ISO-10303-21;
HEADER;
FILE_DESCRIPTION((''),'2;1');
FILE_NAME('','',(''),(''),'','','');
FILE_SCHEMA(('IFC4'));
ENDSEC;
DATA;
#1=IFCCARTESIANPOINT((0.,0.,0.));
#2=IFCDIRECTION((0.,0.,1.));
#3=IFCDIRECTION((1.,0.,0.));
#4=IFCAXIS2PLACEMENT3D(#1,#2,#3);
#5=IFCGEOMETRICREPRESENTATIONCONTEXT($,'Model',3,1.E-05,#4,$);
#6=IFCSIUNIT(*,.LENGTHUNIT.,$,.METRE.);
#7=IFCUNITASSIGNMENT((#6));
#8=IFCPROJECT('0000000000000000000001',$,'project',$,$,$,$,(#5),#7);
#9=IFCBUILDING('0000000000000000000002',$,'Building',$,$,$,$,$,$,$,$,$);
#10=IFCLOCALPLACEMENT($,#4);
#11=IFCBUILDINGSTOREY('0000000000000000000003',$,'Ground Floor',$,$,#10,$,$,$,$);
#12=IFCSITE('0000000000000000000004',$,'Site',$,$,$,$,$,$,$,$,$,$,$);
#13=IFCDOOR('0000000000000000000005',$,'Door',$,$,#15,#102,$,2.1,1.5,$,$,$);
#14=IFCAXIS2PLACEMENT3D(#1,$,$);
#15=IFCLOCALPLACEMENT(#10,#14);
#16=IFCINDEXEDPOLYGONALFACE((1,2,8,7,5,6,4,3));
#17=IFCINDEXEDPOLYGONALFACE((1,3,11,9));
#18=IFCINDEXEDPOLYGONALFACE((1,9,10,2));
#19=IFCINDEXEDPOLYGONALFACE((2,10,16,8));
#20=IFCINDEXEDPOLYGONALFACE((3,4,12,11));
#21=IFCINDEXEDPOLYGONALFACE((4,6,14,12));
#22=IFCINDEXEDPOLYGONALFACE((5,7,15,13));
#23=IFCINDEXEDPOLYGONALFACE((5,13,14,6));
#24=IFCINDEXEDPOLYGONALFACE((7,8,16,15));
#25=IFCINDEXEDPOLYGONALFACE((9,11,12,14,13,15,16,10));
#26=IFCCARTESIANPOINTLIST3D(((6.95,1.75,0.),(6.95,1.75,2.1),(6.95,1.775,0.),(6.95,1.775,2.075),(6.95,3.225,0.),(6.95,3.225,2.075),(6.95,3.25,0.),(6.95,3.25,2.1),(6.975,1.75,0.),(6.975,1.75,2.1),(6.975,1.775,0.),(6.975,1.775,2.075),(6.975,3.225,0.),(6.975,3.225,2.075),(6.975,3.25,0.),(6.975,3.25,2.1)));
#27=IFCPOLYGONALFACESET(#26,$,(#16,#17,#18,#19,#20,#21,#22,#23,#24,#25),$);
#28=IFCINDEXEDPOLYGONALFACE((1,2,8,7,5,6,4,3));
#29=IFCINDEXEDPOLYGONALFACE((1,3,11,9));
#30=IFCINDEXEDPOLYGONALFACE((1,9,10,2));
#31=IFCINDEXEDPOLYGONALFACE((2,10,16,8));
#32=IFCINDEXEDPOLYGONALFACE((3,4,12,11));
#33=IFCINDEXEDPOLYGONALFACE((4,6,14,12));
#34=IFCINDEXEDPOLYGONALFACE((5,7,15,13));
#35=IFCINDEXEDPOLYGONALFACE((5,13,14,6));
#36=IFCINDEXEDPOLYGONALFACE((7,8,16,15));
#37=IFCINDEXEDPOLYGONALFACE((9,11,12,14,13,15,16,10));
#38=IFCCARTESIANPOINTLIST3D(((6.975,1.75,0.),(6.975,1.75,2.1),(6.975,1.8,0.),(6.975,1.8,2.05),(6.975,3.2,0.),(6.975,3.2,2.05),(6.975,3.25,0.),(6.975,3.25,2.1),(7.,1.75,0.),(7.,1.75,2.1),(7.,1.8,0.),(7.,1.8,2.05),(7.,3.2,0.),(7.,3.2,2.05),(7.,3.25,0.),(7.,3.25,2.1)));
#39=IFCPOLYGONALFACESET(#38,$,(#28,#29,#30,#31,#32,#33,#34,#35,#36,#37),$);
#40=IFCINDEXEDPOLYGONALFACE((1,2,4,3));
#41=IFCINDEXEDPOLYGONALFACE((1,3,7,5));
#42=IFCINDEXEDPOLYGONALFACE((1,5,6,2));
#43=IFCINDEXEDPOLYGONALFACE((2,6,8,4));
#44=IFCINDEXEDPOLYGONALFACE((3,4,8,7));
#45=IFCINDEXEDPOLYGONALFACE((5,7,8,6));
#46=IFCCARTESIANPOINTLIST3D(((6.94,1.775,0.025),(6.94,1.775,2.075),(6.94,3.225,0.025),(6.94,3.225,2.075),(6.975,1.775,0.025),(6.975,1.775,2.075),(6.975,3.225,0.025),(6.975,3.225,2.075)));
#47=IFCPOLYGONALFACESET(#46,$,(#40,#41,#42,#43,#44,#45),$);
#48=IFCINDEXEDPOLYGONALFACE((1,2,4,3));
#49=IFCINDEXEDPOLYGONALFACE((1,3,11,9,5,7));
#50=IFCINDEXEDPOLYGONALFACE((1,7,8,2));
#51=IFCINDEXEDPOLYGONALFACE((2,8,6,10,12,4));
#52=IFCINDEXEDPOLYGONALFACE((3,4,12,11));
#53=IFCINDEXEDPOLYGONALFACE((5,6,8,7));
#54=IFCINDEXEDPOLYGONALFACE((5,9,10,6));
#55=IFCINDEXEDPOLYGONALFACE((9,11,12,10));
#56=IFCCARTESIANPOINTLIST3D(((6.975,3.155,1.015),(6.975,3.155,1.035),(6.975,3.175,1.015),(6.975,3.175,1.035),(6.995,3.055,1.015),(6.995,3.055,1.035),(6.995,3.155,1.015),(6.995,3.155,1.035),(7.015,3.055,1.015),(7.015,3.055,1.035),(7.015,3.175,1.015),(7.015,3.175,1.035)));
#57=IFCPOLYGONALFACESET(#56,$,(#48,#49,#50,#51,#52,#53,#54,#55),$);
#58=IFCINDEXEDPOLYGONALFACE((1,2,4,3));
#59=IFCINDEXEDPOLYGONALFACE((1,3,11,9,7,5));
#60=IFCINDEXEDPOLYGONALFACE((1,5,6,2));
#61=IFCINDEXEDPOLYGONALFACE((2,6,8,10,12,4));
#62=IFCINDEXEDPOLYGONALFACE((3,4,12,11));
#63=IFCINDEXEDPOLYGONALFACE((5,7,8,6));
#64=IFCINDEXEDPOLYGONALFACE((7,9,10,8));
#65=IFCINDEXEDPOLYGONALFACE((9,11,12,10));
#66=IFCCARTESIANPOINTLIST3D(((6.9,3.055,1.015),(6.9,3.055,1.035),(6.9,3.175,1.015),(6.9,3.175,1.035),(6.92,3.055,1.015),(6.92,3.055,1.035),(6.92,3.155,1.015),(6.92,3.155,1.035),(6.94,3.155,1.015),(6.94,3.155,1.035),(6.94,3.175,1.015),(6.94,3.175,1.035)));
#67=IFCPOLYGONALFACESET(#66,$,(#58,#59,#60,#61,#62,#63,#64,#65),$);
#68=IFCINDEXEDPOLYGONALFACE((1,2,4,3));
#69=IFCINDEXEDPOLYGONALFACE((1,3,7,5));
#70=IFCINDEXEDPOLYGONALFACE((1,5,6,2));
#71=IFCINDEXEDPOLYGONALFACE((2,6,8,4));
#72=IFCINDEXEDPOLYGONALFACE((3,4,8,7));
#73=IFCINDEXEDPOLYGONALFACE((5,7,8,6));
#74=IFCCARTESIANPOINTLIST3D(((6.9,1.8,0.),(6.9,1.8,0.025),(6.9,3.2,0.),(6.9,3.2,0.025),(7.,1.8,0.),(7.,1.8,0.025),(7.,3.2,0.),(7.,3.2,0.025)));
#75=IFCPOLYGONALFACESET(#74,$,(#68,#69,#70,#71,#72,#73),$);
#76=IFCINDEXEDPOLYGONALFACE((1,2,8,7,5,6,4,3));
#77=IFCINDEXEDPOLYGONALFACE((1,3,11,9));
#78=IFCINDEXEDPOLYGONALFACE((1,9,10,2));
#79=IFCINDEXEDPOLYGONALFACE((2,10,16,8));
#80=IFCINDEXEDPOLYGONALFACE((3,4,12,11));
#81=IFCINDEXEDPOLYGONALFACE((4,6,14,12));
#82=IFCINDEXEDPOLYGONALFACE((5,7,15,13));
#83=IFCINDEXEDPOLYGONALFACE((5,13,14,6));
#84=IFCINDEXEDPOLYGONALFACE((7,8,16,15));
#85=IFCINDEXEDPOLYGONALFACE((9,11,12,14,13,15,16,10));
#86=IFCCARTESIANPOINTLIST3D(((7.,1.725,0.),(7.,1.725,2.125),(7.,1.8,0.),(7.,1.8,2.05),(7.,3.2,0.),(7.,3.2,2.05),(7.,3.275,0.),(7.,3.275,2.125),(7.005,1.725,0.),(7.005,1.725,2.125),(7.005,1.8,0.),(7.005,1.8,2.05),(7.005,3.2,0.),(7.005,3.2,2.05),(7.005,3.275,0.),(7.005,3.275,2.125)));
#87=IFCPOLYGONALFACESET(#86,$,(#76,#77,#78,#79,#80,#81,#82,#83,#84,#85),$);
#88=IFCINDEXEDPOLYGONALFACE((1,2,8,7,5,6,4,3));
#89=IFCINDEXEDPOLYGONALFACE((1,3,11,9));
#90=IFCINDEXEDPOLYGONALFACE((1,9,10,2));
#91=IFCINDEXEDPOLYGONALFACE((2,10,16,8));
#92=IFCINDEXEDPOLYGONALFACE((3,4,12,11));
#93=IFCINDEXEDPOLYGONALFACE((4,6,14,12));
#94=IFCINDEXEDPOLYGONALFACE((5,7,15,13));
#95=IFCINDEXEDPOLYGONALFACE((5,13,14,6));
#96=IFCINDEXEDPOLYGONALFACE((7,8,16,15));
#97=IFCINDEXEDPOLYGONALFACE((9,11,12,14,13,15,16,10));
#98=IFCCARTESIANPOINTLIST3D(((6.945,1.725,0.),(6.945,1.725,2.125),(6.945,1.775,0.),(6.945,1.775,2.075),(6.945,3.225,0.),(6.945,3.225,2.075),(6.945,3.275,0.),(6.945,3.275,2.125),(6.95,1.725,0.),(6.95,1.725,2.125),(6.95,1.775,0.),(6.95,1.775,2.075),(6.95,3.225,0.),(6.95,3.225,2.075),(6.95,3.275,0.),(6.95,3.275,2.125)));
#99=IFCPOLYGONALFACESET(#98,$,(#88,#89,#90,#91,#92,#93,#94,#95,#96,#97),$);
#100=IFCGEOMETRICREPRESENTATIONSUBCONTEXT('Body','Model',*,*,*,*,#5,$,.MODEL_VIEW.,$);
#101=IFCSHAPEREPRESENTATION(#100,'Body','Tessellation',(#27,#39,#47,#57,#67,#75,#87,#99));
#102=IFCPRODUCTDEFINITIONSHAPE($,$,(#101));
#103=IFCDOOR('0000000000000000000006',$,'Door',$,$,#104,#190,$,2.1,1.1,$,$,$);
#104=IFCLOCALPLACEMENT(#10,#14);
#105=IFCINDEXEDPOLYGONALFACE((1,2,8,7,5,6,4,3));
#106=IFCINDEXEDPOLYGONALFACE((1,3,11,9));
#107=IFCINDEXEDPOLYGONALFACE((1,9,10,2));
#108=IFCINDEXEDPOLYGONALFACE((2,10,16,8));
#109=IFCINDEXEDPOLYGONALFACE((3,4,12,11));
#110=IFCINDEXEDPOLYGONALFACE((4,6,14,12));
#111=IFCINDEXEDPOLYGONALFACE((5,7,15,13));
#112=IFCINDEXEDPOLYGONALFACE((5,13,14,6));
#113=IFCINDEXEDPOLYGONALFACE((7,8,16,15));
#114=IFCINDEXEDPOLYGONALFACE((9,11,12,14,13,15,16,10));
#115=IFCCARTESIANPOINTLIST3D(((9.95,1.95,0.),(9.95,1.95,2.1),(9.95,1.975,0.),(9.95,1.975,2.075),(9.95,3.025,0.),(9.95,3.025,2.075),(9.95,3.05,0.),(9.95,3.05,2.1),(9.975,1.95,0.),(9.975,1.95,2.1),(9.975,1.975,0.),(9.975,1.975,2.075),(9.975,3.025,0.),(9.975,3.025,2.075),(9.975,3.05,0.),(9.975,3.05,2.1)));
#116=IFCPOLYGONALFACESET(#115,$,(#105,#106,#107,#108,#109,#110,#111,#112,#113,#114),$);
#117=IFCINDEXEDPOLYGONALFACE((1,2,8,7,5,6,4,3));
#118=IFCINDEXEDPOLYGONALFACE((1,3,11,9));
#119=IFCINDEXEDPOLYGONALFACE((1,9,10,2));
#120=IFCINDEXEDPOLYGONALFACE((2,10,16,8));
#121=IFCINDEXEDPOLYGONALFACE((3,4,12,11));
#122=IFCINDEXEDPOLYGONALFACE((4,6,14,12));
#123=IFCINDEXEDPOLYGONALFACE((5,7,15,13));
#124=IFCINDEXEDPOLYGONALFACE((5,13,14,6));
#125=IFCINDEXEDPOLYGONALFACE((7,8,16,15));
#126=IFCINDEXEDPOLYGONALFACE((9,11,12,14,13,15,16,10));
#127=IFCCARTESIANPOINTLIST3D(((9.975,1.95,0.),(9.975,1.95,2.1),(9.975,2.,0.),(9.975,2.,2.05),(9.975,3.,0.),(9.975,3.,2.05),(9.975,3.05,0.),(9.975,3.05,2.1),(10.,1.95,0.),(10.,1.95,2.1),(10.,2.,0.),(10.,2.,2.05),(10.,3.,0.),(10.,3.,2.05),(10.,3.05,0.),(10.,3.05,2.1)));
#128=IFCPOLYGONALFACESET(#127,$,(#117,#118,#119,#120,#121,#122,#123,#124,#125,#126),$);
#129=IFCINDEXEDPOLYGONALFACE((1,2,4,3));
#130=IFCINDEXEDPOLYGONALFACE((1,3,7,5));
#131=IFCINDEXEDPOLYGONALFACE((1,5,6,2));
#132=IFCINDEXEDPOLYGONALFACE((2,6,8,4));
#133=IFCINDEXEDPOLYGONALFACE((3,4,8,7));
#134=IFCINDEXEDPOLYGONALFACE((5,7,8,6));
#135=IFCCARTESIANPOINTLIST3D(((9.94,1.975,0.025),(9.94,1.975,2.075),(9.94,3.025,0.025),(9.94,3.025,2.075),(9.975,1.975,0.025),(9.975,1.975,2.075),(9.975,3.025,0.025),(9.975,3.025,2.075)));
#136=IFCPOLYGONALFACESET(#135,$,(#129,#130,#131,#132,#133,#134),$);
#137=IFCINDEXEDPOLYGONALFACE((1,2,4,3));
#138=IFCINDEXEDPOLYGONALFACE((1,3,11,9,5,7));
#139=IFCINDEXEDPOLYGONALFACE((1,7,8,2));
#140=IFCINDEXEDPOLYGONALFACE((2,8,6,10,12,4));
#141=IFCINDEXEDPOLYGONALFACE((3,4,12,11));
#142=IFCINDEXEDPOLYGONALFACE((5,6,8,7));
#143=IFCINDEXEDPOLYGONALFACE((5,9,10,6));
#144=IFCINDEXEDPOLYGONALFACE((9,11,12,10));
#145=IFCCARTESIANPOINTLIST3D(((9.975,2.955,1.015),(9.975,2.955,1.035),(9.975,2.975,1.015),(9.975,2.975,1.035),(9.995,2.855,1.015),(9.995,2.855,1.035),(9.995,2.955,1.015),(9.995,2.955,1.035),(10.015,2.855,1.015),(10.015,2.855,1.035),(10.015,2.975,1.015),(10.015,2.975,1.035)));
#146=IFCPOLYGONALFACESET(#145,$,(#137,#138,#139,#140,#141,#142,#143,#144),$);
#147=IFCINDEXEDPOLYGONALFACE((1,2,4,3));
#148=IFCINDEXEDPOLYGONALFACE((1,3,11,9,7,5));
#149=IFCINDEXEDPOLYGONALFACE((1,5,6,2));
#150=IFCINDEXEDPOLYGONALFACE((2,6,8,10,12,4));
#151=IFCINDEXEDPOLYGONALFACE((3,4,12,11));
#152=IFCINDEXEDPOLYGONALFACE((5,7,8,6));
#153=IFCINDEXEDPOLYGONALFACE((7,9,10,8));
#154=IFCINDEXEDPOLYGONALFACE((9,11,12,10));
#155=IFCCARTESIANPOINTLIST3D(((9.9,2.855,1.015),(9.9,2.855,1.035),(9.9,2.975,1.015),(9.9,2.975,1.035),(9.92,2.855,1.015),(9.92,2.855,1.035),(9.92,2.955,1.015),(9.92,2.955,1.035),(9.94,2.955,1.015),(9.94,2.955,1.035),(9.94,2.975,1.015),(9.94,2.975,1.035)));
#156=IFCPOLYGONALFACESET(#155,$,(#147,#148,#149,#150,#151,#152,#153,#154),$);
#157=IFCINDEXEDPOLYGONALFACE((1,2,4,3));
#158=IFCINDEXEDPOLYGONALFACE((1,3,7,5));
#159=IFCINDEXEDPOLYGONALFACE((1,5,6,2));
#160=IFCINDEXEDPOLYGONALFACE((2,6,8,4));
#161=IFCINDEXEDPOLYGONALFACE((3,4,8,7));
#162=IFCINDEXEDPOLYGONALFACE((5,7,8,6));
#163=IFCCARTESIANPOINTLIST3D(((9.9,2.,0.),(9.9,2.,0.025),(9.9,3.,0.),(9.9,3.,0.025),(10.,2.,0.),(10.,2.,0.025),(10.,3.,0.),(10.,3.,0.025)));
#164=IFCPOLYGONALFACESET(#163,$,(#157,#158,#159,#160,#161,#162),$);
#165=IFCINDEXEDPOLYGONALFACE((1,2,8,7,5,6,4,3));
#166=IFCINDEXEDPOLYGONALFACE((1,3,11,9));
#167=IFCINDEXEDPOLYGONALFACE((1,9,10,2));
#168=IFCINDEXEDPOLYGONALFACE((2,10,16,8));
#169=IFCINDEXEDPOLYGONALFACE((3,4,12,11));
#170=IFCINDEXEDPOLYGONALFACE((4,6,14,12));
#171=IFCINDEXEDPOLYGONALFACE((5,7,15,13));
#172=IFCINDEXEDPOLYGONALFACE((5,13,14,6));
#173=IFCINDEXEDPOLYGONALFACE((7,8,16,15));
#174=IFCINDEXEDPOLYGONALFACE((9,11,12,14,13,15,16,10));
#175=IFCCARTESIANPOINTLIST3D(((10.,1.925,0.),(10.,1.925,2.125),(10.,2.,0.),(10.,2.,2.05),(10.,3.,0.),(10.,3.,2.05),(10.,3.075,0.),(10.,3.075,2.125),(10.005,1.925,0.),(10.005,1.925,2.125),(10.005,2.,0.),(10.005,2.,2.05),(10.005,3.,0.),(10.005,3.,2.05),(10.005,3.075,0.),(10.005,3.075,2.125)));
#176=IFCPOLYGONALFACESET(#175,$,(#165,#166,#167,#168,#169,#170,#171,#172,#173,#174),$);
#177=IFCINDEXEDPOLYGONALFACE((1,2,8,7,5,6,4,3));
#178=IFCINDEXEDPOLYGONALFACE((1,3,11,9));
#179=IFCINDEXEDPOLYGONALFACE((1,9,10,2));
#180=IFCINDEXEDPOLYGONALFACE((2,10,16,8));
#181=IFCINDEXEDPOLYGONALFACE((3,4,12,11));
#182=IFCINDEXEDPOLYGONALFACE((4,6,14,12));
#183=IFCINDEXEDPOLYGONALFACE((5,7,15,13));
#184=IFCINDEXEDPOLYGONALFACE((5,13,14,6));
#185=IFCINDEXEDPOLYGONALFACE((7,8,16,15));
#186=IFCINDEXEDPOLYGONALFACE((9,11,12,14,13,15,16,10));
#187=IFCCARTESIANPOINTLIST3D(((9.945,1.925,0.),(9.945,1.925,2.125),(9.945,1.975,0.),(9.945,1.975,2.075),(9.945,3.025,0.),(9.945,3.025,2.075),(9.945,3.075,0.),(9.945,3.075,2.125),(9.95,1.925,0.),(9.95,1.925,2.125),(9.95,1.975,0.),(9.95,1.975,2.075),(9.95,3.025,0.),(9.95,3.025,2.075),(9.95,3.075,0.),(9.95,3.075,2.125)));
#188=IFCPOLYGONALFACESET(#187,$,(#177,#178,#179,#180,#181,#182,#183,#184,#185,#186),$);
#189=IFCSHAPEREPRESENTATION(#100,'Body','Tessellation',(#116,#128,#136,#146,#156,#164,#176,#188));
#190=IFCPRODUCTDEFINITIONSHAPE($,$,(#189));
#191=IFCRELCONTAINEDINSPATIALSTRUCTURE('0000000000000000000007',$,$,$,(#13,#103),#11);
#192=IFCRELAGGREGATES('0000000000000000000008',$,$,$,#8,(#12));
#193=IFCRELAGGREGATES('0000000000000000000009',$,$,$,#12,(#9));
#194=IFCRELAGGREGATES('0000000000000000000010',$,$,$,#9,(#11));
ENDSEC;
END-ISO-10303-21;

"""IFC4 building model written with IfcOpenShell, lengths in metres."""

from ifc_helpers import new_model, si_unit, frame, origin_with_axes, place, context, subcontext, project, spatial, line, indexed_curve, outline, extrude, element, save


model = new_model("IFC4")

# Units and contexts
model_context = context("Model", 3, precision=1e-05, world=origin_with_axes())
body_context = subcontext(model_context, "Body", "Model", "MODEL_VIEW")
ifc_project = project(units=[si_unit("LENGTHUNIT", "METRE")], contexts=[model_context])

# Site, building, storey
site = spatial("IfcSite", under=ifc_project, Name="Site")
building = spatial("IfcBuilding", under=site, Name="Building")
storey_placement = place(None, origin_with_axes())
storey = spatial("IfcBuildingStorey", under=building, at=storey_placement, Name="Ground Floor")

# Doors
door_1_placement = place(storey_placement, frame((7.0, 1.75, 0.0), z_axis=(0.0, 0.0, 1.0), x_axis=(0.0, 1.0, 0.0)))
element("IfcDoor", 1, at=door_1_placement, inside=storey, Name="Door", OverallHeight=2.1, OverallWidth=1.5, context=body_context, shape_type="SweptSolid", body=[
    extrude(outline(indexed_curve([(0.0, 0.0), (0.0, 2.1), (1.5, 2.1), (1.5, 0.0), (1.475, 0.0), (1.475, 2.075), (0.025, 2.075), (0.025, 0.0)], segments=[line(1, 2, 3, 4, 5, 6, 7, 8, 1)])), frame((0.0, 0.025, 0.0), z_axis=(0.0, -1.0, 0.0), x_axis=(1.0, 0.0, 0.0)), (0.0, 0.0, -1.0), 0.025),
    extrude(outline(indexed_curve([(0.0, 0.0), (0.0, 2.1), (1.5, 2.1), (1.5, 0.0), (1.45, 0.0), (1.45, 2.05), (0.05, 2.05), (0.05, 0.0)], segments=[line(1, 2, 3, 4, 5, 6, 7, 8, 1)])), frame((0.0, 0.0, 0.0), z_axis=(0.0, -1.0, 0.0), x_axis=(1.0, 0.0, 0.0)), (0.0, 0.0, -1.0), 0.025),
    extrude(outline(indexed_curve([(0.0, 0.0), (1.45, 0.0), (1.45, 0.035), (0.0, 0.035)], segments=[line(1, 2, 3, 4, 1)])), frame((0.025, 0.025, 0.025), z_axis=(0.0, 0.0, 1.0), x_axis=(1.0, 0.0, 0.0)), (0.0, 0.0, 1.0), 2.05),
    extrude(outline(indexed_curve([(0.0, 0.0), (0.0, -0.04), (-0.12, -0.04), (-0.12, -0.02), (-0.02, -0.02), (-0.02, 0.0)], segments=[line(1, 2, 3, 4, 5, 6, 1)])), frame((1.425, 0.025, 1.015), z_axis=(0.0, 0.0, 1.0), x_axis=(1.0, 0.0, 0.0)), (0.0, 0.0, 1.0), 0.02),
    extrude(outline(indexed_curve([(0.0, 0.0), (0.0, 0.04), (-0.12, 0.04), (-0.12, 0.02), (-0.02, 0.02), (-0.02, 0.0)], segments=[line(1, 2, 3, 4, 5, 6, 1)])), frame((1.425, 0.06, 1.015), z_axis=(0.0, 0.0, 1.0), x_axis=(1.0, 0.0, 0.0)), (0.0, 0.0, 1.0), 0.02),
    extrude(outline(indexed_curve([(0.0, 0.0), (1.4, 0.0), (1.4, 0.1), (0.0, 0.1)], segments=[line(1, 2, 3, 4, 1)])), frame((0.05, 0.0, 0.0), z_axis=(0.0, 0.0, 1.0), x_axis=(1.0, 0.0, 0.0)), (0.0, 0.0, 1.0), 0.025),
    extrude(outline(indexed_curve([(0.0, 0.0), (0.0, 2.125), (1.55, 2.125), (1.55, 0.0), (1.475, 0.0), (1.475, 2.05), (0.075, 2.05), (0.075, 0.0)], segments=[line(1, 2, 3, 4, 5, 6, 7, 8, 1)])), frame((-0.025, -0.005, 0.0), z_axis=(0.0, -1.0, 0.0), x_axis=(1.0, 0.0, 0.0)), (0.0, 0.0, -1.0), 0.005),
    extrude(outline(indexed_curve([(0.0, 0.0), (0.0, 2.125), (1.55, 2.125), (1.55, 0.0), (1.5, 0.0), (1.5, 2.075), (0.05, 2.075), (0.05, 0.0)], segments=[line(1, 2, 3, 4, 5, 6, 7, 8, 1)])), frame((-0.025, 0.05, 0.0), z_axis=(0.0, -1.0, 0.0), x_axis=(1.0, 0.0, 0.0)), (0.0, 0.0, -1.0), 0.005),
])
door_2_placement = place(storey_placement, frame((10.0, 1.95, 0.0), z_axis=(0.0, 0.0, 1.0), x_axis=(0.0, 1.0, 0.0)))
element("IfcDoor", 2, at=door_2_placement, inside=storey, Name="Door", OverallHeight=2.1, OverallWidth=1.1, context=body_context, shape_type="SweptSolid", body=[
    extrude(outline(indexed_curve([(0.0, 0.0), (0.0, 2.1), (1.1, 2.1), (1.1, 0.0), (1.075, 0.0), (1.075, 2.075), (0.025, 2.075), (0.025, 0.0)], segments=[line(1, 2, 3, 4, 5, 6, 7, 8, 1)])), frame((0.0, 0.025, 0.0), z_axis=(0.0, -1.0, 0.0), x_axis=(1.0, 0.0, 0.0)), (0.0, 0.0, -1.0), 0.025),
    extrude(outline(indexed_curve([(0.0, 0.0), (0.0, 2.1), (1.1, 2.1), (1.1, 0.0), (1.05, 0.0), (1.05, 2.05), (0.05, 2.05), (0.05, 0.0)], segments=[line(1, 2, 3, 4, 5, 6, 7, 8, 1)])), frame((0.0, 0.0, 0.0), z_axis=(0.0, -1.0, 0.0), x_axis=(1.0, 0.0, 0.0)), (0.0, 0.0, -1.0), 0.025),
    extrude(outline(indexed_curve([(0.0, 0.0), (1.05, 0.0), (1.05, 0.035), (0.0, 0.035)], segments=[line(1, 2, 3, 4, 1)])), frame((0.025, 0.025, 0.025), z_axis=(0.0, 0.0, 1.0), x_axis=(1.0, 0.0, 0.0)), (0.0, 0.0, 1.0), 2.05),
    extrude(outline(indexed_curve([(0.0, 0.0), (0.0, -0.04), (-0.12, -0.04), (-0.12, -0.02), (-0.02, -0.02), (-0.02, 0.0)], segments=[line(1, 2, 3, 4, 5, 6, 1)])), frame((1.025, 0.025, 1.015), z_axis=(0.0, 0.0, 1.0), x_axis=(1.0, 0.0, 0.0)), (0.0, 0.0, 1.0), 0.02),
    extrude(outline(indexed_curve([(0.0, 0.0), (0.0, 0.04), (-0.12, 0.04), (-0.12, 0.02), (-0.02, 0.02), (-0.02, 0.0)], segments=[line(1, 2, 3, 4, 5, 6, 1)])), frame((1.025, 0.06, 1.015), z_axis=(0.0, 0.0, 1.0), x_axis=(1.0, 0.0, 0.0)), (0.0, 0.0, 1.0), 0.02),
    extrude(outline(indexed_curve([(0.0, 0.0), (1.0, 0.0), (1.0, 0.1), (0.0, 0.1)], segments=[line(1, 2, 3, 4, 1)])), frame((0.05, 0.0, 0.0), z_axis=(0.0, 0.0, 1.0), x_axis=(1.0, 0.0, 0.0)), (0.0, 0.0, 1.0), 0.025),
    extrude(outline(indexed_curve([(0.0, 0.0), (0.0, 2.125), (1.15, 2.125), (1.15, 0.0), (1.075, 0.0), (1.075, 2.05), (0.075, 2.05), (0.075, 0.0)], segments=[line(1, 2, 3, 4, 5, 6, 7, 8, 1)])), frame((-0.025, -0.005, 0.0), z_axis=(0.0, -1.0, 0.0), x_axis=(1.0, 0.0, 0.0)), (0.0, 0.0, -1.0), 0.005),
    extrude(outline(indexed_curve([(0.0, 0.0), (0.0, 2.125), (1.15, 2.125), (1.15, 0.0), (1.1, 0.0), (1.1, 2.075), (0.05, 2.075), (0.05, 0.0)], segments=[line(1, 2, 3, 4, 5, 6, 7, 8, 1)])), frame((-0.025, 0.05, 0.0), z_axis=(0.0, -1.0, 0.0), x_axis=(1.0, 0.0, 0.0)), (0.0, 0.0, -1.0), 0.005),
])

save(model, "model.ifc")
